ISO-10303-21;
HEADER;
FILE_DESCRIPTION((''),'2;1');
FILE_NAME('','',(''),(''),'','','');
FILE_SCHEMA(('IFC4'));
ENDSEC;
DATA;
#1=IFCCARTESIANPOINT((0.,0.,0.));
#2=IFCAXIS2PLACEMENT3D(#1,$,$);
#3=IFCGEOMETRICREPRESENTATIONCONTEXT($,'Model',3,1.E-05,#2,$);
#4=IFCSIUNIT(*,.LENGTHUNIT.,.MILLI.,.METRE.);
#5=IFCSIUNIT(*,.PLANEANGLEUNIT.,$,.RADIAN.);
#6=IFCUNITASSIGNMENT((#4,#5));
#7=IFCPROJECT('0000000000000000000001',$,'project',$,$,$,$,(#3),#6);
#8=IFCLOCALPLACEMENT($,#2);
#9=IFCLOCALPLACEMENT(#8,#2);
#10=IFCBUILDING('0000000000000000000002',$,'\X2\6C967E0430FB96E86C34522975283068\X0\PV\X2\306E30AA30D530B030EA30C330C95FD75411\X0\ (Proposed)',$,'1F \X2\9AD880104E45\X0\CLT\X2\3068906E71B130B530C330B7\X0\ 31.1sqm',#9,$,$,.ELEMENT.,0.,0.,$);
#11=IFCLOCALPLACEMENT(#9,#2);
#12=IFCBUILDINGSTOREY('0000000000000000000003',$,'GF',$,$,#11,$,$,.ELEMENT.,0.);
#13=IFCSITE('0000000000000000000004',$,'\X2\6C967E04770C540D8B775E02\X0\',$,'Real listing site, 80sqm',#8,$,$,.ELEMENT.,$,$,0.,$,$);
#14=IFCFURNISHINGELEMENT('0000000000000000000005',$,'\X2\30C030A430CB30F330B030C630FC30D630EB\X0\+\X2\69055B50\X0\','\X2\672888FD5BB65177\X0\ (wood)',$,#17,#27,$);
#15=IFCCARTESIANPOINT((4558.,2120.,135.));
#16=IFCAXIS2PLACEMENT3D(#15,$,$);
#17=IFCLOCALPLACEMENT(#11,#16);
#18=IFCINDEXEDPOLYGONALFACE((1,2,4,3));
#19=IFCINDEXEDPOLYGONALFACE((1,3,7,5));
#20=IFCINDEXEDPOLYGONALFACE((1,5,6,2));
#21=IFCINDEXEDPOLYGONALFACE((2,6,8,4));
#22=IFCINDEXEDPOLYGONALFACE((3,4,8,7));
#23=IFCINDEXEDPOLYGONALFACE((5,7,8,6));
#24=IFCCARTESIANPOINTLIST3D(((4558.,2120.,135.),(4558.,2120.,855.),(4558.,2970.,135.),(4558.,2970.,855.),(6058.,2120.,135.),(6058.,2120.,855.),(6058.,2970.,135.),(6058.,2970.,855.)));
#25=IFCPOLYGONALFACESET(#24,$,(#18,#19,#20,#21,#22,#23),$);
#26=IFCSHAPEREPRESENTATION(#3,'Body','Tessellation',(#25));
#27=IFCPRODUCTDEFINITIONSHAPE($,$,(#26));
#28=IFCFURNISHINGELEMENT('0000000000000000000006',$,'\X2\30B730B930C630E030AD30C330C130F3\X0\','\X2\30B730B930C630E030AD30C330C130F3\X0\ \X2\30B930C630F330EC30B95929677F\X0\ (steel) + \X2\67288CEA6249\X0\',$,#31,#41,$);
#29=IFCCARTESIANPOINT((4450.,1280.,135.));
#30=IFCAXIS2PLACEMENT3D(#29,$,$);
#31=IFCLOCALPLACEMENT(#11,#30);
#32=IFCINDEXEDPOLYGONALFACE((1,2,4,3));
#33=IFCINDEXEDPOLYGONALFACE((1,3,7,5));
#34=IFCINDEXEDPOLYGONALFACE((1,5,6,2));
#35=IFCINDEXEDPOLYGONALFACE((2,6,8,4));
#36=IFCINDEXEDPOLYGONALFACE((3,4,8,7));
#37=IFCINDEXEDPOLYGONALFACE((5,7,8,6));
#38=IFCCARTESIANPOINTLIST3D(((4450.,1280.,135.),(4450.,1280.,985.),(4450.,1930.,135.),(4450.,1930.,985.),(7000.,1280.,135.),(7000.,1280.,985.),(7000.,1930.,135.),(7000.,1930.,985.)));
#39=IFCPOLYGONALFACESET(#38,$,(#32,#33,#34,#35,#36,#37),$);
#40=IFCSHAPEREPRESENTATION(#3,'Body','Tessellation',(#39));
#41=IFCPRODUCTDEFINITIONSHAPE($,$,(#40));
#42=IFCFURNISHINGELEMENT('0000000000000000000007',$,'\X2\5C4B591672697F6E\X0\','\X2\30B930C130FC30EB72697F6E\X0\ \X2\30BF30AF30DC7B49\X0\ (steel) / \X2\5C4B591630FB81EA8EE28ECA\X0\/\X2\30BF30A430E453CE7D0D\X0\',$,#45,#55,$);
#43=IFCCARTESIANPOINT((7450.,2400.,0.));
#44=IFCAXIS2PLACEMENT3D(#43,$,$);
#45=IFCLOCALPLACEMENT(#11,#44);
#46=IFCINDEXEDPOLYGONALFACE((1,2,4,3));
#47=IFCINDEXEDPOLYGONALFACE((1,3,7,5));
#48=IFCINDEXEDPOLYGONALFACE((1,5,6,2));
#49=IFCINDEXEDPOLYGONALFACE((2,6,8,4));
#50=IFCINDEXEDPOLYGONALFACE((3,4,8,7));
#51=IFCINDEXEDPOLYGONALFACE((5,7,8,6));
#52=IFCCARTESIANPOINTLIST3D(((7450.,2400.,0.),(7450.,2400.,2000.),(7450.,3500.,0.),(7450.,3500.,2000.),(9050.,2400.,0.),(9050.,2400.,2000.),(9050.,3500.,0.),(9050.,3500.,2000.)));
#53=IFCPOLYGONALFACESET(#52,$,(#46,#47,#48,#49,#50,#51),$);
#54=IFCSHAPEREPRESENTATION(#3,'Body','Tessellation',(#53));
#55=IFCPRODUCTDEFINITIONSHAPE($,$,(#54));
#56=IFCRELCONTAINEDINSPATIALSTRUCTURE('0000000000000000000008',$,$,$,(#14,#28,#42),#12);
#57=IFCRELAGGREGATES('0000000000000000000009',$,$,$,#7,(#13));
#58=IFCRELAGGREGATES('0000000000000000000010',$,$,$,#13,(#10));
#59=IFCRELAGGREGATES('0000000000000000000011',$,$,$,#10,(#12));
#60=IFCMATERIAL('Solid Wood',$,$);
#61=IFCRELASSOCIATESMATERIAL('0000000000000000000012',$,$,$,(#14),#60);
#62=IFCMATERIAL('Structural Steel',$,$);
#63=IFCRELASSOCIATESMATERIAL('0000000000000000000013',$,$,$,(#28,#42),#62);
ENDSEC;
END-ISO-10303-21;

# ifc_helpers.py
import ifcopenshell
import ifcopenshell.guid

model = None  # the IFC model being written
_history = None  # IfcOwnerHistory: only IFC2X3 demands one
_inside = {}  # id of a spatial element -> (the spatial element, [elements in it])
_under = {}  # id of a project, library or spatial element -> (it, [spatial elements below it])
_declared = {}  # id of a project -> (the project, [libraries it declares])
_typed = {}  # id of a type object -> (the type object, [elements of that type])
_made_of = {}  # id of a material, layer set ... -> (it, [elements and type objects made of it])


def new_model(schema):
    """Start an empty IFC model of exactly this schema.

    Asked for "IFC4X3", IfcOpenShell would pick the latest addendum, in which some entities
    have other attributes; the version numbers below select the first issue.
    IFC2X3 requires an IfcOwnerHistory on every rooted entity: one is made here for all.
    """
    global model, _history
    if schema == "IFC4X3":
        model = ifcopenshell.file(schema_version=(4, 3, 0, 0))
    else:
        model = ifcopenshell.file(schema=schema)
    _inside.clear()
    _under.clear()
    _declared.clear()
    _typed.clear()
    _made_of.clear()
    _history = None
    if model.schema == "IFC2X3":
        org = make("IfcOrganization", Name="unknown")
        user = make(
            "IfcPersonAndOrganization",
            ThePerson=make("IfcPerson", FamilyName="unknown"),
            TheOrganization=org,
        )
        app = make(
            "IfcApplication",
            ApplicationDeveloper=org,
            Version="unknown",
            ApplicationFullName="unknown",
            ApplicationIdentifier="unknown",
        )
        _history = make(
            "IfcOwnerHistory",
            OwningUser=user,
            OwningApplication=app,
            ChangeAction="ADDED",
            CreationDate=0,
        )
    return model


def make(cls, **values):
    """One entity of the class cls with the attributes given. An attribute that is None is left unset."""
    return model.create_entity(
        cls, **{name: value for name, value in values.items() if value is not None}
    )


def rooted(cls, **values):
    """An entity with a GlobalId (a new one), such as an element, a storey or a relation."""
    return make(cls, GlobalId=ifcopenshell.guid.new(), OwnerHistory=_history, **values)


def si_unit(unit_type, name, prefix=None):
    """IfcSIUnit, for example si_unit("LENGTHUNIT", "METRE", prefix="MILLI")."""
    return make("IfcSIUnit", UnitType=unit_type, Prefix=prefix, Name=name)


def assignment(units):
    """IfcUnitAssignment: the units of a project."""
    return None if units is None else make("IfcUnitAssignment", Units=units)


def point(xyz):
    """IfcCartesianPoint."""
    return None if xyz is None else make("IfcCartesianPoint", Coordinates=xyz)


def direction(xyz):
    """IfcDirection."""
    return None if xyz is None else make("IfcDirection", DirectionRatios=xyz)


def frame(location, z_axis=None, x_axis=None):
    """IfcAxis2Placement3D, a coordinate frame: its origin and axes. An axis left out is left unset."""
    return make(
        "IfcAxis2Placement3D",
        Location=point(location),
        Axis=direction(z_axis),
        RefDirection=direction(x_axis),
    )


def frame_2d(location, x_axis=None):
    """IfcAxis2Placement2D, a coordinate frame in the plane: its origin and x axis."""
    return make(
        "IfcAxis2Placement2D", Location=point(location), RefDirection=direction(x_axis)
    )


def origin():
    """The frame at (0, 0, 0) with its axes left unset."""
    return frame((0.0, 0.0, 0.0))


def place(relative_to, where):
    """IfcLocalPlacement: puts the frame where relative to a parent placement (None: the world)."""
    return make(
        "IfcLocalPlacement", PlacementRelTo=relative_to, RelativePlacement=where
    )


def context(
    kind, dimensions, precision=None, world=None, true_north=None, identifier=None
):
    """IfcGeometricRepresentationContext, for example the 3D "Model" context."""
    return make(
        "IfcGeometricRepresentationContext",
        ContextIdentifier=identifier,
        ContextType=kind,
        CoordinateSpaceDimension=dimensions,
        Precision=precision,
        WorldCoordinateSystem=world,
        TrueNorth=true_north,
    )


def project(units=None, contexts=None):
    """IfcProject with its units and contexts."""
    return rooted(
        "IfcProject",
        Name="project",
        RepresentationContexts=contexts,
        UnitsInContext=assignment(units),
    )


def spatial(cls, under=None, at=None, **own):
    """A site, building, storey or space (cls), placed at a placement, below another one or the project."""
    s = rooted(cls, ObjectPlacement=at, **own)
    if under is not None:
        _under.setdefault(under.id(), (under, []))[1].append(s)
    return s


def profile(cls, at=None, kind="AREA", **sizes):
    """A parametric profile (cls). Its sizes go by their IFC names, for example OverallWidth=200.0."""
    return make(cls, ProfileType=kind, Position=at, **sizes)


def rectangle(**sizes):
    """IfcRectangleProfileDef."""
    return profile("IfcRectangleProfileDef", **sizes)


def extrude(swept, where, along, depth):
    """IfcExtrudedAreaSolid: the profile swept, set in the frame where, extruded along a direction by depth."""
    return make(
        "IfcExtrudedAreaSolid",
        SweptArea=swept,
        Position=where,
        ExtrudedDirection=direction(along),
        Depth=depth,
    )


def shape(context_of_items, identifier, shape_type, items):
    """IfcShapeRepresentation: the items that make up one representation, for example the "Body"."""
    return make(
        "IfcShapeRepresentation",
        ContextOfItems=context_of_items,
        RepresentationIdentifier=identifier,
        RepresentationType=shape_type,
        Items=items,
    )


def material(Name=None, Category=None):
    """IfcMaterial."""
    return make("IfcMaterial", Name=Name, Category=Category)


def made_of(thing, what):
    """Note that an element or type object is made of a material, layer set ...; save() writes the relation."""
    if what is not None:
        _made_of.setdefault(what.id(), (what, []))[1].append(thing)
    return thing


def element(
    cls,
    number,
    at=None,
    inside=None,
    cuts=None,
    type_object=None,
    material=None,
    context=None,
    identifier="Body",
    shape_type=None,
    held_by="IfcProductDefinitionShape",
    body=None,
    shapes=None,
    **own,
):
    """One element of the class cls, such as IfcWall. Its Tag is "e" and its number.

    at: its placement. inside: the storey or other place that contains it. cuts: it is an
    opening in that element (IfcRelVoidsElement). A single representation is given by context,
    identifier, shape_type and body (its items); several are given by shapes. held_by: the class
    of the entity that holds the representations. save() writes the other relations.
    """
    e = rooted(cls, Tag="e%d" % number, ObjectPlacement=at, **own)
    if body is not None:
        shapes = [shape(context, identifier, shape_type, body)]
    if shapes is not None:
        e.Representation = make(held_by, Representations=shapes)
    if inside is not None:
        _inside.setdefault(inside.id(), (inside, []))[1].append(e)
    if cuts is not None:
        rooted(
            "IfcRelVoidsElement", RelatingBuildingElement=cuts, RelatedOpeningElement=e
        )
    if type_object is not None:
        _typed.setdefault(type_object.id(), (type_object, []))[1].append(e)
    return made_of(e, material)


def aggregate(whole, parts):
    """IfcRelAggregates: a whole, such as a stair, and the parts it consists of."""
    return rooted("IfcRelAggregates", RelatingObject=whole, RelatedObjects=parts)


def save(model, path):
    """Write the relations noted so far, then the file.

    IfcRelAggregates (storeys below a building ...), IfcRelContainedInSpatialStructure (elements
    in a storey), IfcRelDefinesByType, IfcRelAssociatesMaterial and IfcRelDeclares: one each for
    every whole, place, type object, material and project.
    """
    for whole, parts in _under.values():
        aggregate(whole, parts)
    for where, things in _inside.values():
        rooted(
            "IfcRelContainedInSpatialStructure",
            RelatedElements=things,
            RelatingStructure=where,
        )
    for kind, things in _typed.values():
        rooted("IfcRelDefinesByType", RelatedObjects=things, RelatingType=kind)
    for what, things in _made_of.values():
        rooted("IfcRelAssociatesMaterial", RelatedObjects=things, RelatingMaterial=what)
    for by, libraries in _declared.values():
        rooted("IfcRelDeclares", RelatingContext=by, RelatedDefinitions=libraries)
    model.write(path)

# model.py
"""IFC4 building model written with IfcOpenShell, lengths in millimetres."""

from ifc_helpers import new_model, si_unit, frame, frame_2d, origin, place, context, project, spatial, rectangle, extrude, material, element, save


model = new_model("IFC4")

# Units and contexts
model_context = context("Model", 3, precision=1e-05, world=origin())
ifc_project = project(units=[si_unit("LENGTHUNIT", "METRE", prefix="MILLI"), si_unit("PLANEANGLEUNIT", "RADIAN")], contexts=[model_context])

# Site, building, storey
site_placement = place(None, origin())
site = spatial("IfcSite", under=ifc_project, at=site_placement, Name="沖縄県名護市", ObjectType="Real listing site, 80sqm", CompositionType="ELEMENT", RefElevation=0.0)
building_placement = place(site_placement, origin())
building = spatial("IfcBuilding", under=site, at=building_placement, Name="沖縄・雨水利用とPVのオフグリッド志向 (Proposed)", ObjectType="1F 高耐久CLTと遮熱サッシ 31.1sqm", CompositionType="ELEMENT", ElevationOfRefHeight=0.0, ElevationOfTerrain=0.0)
storey_placement = place(building_placement, origin())
storey = spatial("IfcBuildingStorey", under=building, at=storey_placement, Name="GF", CompositionType="ELEMENT", Elevation=0.0)

# Shared definitions
ifc_material_1 = material(Name="Solid Wood")

# Shared definitions
ifc_material_2 = material(Name="Structural Steel")

# Furnishing elements
furnishing_1_placement = place(storey_placement, frame((4558.0, 2120.0, 135.0)))
element("IfcFurnishingElement", 1, at=furnishing_1_placement, inside=storey, material=ifc_material_1, Name="ダイニングテーブル+椅子", Description="木製家具 (wood)", context=model_context, shape_type="SweptSolid", body=[
    extrude(rectangle(XDim=1500.0, YDim=850.0, at=frame_2d((750.0, 425.0))), frame((4558.0, 2120.0, 135.0)), (0.0, 0.0, 1.0), 720.0),
])
furnishing_2_placement = place(storey_placement, frame((4450.0, 1280.0, 135.0)))
element("IfcFurnishingElement", 2, at=furnishing_2_placement, inside=storey, material=ifc_material_2, Name="システムキッチン", Description="システムキッチン ステンレス天板 (steel) + 木質扉", context=model_context, shape_type="SweptSolid", body=[
    extrude(rectangle(XDim=2550.0, YDim=650.0, at=frame_2d((1275.0, 325.0))), frame((4450.0, 1280.0, 135.0)), (0.0, 0.0, 1.0), 850.0),
])
furnishing_3_placement = place(storey_placement, frame((7450.0, 2400.0, 0.0)))
element("IfcFurnishingElement", 3, at=furnishing_3_placement, inside=storey, material=ifc_material_2, Name="屋外物置", Description="スチール物置 タクボ等 (steel) / 屋外・自転車/タイヤ収納", context=model_context, shape_type="SweptSolid", body=[
    extrude(rectangle(XDim=1600.0, YDim=1100.0, at=frame_2d((800.0, 550.0))), frame((7450.0, 2400.0, 0.0)), (0.0, 0.0, 1.0), 2000.0),
])

save(model, "model.ifc")
